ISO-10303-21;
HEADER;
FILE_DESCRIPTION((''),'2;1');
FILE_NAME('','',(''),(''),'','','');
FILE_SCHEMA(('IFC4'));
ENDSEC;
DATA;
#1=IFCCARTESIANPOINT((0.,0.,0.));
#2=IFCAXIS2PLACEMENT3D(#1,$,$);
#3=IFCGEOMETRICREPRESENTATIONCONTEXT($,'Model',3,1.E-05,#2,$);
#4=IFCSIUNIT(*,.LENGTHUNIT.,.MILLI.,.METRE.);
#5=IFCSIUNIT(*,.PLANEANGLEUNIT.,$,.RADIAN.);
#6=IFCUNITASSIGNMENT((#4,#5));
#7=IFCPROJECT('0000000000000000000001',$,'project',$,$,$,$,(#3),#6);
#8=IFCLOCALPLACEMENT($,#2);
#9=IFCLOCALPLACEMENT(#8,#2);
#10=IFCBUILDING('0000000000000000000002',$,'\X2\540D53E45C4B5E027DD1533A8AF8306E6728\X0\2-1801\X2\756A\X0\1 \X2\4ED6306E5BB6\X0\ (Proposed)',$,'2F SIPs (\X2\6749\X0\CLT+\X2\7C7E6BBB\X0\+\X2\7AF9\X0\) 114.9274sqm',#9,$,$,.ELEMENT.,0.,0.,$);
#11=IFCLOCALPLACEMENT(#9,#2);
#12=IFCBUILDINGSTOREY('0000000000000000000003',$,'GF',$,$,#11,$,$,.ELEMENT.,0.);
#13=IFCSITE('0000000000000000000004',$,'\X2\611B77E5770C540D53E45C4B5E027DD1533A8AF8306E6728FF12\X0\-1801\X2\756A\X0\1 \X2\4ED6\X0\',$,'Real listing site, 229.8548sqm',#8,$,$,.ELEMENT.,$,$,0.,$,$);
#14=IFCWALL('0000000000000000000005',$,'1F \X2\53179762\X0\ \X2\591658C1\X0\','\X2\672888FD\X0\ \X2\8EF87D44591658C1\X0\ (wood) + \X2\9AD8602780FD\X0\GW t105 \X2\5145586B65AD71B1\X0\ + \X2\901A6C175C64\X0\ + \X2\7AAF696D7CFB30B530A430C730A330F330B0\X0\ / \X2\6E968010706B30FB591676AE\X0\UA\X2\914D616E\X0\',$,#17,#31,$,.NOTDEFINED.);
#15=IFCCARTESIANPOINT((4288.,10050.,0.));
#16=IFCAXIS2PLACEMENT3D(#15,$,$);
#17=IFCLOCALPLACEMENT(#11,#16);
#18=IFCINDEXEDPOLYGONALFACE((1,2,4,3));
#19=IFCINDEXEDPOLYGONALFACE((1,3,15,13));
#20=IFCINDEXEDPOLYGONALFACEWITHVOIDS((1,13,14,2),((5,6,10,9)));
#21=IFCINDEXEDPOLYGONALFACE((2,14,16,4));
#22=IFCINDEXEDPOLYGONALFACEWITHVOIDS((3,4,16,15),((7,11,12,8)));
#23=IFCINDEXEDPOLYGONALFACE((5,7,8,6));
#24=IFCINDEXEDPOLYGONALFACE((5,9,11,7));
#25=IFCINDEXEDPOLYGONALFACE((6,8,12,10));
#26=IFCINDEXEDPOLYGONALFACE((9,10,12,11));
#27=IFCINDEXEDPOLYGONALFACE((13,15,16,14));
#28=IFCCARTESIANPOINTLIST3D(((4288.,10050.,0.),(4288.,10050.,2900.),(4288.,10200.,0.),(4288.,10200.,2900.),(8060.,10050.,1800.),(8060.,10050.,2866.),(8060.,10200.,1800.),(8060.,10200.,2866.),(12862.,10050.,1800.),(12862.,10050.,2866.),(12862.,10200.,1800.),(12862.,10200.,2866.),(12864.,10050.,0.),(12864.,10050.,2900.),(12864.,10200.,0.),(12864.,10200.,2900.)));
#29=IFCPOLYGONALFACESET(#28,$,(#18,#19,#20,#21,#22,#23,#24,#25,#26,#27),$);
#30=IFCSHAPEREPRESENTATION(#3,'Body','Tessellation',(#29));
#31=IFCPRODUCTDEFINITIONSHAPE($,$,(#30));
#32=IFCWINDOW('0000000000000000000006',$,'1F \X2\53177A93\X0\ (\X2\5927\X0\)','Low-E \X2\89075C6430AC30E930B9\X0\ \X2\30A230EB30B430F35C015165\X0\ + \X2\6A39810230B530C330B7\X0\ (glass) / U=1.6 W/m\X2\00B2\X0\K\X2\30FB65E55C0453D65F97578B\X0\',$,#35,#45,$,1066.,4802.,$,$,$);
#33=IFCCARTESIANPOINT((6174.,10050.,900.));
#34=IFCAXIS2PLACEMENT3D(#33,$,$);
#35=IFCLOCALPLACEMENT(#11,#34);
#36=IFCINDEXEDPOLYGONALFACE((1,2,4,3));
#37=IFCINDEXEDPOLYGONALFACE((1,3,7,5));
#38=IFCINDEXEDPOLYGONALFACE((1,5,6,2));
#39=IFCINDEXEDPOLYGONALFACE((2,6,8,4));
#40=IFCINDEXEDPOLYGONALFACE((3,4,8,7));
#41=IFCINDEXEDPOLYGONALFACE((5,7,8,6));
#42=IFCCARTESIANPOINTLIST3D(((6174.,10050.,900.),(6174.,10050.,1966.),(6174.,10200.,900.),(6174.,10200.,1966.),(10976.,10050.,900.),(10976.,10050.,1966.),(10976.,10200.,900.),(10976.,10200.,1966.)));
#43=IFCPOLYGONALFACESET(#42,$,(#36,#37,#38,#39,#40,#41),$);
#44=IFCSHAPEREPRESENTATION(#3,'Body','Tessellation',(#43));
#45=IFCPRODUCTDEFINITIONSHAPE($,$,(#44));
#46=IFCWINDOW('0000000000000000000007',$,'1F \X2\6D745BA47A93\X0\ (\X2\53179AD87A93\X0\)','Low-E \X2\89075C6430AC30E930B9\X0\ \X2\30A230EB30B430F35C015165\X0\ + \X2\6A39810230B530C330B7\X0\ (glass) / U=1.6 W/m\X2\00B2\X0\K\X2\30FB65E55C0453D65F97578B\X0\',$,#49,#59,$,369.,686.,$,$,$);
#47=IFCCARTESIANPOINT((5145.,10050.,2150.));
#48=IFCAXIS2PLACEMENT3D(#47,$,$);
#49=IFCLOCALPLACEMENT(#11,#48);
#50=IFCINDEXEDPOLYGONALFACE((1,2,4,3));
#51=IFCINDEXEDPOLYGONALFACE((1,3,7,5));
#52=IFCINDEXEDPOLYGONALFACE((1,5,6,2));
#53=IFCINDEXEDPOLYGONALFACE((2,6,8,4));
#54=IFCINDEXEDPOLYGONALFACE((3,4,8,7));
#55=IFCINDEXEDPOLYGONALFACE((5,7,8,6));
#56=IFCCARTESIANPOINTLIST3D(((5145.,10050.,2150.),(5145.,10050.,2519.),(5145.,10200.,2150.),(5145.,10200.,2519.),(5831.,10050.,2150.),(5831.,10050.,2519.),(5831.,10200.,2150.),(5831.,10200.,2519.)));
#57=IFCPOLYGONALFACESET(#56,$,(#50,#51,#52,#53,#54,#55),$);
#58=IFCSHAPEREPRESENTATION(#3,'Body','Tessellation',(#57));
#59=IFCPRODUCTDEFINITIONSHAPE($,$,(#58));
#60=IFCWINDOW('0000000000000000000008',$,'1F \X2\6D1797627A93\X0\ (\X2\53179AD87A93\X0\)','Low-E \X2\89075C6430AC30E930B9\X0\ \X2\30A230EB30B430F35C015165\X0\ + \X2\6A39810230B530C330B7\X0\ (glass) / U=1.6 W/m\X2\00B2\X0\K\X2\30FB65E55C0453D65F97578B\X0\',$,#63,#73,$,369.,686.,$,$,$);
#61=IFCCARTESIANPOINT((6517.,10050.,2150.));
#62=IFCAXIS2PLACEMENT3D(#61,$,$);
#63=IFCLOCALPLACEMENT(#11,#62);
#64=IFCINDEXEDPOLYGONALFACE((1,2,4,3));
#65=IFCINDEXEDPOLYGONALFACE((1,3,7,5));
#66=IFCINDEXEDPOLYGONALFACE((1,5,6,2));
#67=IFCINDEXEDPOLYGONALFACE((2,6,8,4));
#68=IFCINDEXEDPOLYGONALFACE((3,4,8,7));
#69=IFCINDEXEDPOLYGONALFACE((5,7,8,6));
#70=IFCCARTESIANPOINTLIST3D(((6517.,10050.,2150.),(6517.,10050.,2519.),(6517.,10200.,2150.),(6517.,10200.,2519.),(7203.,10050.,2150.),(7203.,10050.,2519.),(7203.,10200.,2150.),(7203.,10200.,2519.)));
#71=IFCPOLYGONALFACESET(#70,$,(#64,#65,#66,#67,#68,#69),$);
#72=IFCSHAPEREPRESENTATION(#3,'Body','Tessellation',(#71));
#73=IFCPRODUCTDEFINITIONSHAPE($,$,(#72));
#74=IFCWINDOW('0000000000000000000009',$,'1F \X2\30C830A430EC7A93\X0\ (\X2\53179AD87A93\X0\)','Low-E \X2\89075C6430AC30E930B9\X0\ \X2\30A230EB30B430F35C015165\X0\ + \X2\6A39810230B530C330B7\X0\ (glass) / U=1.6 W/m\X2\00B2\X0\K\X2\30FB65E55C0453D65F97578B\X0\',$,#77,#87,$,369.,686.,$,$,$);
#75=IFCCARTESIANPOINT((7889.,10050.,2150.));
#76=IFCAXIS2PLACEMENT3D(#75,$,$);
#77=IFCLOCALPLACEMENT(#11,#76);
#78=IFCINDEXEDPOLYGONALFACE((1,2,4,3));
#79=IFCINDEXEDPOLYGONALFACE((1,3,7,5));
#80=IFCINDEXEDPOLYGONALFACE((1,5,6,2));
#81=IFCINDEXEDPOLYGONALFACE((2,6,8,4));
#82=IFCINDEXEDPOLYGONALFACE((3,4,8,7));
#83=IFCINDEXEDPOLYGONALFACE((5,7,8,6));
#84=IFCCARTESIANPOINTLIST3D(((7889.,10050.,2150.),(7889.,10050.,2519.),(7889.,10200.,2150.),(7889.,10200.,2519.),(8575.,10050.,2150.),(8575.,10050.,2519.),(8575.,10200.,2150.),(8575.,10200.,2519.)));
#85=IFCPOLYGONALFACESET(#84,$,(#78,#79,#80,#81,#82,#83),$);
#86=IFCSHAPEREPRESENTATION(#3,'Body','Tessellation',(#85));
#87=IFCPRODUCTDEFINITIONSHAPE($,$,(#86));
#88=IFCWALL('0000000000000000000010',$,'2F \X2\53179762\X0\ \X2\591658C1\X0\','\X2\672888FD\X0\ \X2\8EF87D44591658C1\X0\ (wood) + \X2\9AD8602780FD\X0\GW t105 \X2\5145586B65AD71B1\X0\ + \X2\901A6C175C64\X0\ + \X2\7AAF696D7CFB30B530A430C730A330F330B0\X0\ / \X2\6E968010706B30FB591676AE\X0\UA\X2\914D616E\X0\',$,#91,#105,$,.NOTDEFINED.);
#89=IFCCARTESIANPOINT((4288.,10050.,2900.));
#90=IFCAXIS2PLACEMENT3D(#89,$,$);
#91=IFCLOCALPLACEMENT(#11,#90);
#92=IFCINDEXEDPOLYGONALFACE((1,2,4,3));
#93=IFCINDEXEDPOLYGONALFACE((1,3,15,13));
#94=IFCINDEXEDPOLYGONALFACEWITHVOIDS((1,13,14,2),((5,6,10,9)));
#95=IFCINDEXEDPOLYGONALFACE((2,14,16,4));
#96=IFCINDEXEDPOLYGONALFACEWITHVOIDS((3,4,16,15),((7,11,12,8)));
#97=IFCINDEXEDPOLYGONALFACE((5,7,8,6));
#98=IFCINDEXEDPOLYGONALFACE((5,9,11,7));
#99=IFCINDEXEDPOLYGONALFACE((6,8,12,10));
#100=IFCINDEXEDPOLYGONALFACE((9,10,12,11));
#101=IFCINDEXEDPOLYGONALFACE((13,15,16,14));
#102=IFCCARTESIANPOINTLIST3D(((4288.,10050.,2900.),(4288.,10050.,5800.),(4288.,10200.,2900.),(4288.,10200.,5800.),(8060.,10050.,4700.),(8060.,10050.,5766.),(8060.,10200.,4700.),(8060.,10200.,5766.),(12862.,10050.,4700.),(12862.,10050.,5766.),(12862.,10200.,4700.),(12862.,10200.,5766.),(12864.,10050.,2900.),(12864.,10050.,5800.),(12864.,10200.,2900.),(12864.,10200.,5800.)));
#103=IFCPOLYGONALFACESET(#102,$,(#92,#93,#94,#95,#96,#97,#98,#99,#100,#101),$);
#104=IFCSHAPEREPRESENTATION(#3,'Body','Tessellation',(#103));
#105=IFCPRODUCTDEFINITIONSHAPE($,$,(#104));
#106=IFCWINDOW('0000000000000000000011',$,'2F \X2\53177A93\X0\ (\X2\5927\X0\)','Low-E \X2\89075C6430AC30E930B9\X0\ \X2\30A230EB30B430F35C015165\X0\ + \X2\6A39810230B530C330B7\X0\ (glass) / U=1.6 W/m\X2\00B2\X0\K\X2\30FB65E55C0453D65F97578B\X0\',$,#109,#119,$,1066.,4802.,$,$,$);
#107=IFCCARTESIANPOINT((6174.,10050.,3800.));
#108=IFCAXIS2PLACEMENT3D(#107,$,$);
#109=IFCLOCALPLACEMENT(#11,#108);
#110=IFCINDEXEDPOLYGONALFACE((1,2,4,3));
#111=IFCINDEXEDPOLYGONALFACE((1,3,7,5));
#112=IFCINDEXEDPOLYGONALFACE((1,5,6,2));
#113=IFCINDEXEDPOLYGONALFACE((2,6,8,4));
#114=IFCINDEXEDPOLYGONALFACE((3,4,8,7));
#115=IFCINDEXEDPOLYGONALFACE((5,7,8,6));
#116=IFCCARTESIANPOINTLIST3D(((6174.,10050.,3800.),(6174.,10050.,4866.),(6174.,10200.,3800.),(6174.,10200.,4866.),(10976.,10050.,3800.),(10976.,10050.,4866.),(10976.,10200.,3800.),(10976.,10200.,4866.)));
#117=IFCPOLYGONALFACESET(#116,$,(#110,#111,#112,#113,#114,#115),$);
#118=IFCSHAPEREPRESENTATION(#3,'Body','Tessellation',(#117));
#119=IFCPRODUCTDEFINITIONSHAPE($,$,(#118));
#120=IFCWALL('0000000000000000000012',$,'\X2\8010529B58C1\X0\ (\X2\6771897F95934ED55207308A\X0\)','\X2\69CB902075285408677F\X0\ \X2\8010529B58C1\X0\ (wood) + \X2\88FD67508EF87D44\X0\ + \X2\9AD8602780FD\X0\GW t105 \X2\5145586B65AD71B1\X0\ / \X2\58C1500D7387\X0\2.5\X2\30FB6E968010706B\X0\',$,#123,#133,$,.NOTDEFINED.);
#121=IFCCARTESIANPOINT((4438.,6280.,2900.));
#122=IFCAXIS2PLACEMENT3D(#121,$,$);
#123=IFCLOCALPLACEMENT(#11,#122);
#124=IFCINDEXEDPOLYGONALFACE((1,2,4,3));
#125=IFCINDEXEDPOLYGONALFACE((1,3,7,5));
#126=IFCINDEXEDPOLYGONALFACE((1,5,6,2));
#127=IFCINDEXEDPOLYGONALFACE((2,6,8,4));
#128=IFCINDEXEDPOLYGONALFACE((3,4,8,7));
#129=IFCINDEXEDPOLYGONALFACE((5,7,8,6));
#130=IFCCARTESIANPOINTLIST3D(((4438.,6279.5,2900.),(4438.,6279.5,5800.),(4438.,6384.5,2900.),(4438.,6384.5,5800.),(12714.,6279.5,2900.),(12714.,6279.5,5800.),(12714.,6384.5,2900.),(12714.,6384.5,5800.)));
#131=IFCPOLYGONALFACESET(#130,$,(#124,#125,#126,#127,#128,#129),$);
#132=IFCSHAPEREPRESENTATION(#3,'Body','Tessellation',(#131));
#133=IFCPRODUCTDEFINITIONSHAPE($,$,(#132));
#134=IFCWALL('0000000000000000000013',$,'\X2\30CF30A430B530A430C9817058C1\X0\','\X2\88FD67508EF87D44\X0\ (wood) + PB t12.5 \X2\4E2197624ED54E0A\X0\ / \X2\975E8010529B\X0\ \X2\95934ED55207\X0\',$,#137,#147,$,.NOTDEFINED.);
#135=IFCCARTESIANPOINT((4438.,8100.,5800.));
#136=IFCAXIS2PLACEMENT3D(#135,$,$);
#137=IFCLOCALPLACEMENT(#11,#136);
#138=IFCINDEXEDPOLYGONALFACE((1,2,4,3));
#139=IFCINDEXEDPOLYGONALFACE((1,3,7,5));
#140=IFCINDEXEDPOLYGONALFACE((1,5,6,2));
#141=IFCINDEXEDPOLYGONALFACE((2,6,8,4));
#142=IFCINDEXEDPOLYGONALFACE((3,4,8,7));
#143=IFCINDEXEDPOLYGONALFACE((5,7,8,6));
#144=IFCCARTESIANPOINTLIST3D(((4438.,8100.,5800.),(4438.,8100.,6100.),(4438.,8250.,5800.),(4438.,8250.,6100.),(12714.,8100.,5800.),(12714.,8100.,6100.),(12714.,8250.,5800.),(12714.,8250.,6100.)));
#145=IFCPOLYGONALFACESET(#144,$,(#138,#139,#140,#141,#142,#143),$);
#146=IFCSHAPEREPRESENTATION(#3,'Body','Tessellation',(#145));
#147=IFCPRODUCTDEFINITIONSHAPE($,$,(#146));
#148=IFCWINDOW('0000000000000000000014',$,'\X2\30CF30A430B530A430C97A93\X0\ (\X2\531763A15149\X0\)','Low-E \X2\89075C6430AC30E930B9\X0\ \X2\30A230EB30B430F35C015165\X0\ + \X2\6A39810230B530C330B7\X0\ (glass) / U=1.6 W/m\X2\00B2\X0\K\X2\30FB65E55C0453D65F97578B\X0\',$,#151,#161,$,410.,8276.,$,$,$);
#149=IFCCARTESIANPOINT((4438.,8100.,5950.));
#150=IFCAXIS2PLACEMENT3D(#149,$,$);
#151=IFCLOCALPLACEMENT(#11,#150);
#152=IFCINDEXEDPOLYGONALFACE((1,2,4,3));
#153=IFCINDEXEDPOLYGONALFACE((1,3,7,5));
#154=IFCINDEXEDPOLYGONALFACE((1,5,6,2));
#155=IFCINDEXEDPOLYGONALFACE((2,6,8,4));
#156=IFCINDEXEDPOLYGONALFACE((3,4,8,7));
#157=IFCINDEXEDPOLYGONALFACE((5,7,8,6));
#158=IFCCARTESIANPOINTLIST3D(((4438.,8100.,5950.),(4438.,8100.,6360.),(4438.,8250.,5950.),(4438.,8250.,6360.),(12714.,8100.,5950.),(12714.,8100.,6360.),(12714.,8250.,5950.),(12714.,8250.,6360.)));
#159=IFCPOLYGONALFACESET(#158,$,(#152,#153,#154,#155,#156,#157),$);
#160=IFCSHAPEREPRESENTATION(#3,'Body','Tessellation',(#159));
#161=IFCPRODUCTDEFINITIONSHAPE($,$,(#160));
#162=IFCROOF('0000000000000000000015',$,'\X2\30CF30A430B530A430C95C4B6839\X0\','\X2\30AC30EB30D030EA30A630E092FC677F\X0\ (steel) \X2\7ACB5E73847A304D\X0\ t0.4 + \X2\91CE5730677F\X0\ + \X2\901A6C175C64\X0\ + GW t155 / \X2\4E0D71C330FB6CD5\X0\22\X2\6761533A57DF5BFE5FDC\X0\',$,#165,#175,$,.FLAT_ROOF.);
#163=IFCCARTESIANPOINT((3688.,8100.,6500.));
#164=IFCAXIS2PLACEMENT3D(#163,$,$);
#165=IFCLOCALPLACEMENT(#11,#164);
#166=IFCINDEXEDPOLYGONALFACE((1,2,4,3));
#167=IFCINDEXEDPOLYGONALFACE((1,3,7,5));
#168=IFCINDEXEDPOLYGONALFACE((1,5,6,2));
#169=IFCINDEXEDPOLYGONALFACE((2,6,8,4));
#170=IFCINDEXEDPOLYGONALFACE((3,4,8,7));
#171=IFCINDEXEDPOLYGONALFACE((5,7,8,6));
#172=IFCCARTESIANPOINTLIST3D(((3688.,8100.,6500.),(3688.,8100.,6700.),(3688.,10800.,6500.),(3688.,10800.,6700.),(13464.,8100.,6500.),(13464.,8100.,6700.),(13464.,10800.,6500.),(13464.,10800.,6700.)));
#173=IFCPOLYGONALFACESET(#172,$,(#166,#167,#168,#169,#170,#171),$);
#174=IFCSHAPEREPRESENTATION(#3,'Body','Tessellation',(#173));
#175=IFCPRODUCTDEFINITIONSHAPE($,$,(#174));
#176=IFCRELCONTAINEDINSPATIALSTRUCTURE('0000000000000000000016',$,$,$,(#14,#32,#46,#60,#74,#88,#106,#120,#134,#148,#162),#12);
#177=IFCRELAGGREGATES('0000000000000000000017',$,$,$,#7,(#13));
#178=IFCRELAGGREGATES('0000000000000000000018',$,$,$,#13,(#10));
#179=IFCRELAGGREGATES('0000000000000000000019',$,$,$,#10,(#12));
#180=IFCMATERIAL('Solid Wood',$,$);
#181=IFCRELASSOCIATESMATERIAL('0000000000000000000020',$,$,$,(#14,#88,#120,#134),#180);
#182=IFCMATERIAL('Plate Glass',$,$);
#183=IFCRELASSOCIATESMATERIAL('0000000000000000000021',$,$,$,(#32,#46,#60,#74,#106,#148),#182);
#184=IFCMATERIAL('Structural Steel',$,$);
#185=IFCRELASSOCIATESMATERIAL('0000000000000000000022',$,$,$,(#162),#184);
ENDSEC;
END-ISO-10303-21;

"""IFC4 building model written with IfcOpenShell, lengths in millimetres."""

from ifc_helpers import new_model, si_unit, frame, frame_2d, origin, place, context, project, spatial, rectangle, extrude, material, element, fill, save


model = new_model("IFC4")

# Units and contexts
model_context = context("Model", 3, precision=1e-05, world=origin())
ifc_project = project(units=[si_unit("LENGTHUNIT", "METRE", prefix="MILLI"), si_unit("PLANEANGLEUNIT", "RADIAN")], contexts=[model_context])

# Site, building, storey
site_placement = place(None, origin())
site = spatial("IfcSite", under=ifc_project, at=site_placement, Name="愛知県名古屋市緑区諸の木２-1801番1 他", ObjectType="Real listing site, 229.8548sqm", CompositionType="ELEMENT", RefElevation=0.0)
building_placement = place(site_placement, origin())
building = spatial("IfcBuilding", under=site, at=building_placement, Name="名古屋市緑区諸の木2-1801番1 他の家 (Proposed)", ObjectType="2F SIPs (杉CLT+籾殻+竹) 114.9274sqm", CompositionType="ELEMENT", ElevationOfRefHeight=0.0, ElevationOfTerrain=0.0)
storey_placement = place(building_placement, origin())
storey = spatial("IfcBuildingStorey", under=building, at=storey_placement, Name="GF", CompositionType="ELEMENT", Elevation=0.0)

# Wall, openings, windows
ifc_material_1 = material(Name="Solid Wood")
wall_1_placement = place(storey_placement, frame((4288.0, 10050.0, 0.0)))
wall_1 = element("IfcWall", 1, at=wall_1_placement, inside=storey, material=ifc_material_1, Name="1F 北面 外壁", Description="木製 軸組外壁 (wood) + 高性能GW t105 充填断熱 + 通気層 + 窯業系サイディング / 準耐火・外皮UA配慮", PredefinedType="NOTDEFINED", context=model_context, shape_type="SweptSolid", body=[
    extrude(rectangle(XDim=8576.0, YDim=150.0, at=frame_2d((4288.0, 75.0))), frame((4288.0, 10050.0, 0.0)), (0.0, 0.0, 1.0), 2900.0),
])
opening_1_placement = place(storey_placement, frame((6174.0, 10050.0, 900.0)))
opening_1 = element("IfcOpeningElement", 2, at=opening_1_placement, cuts=wall_1, PredefinedType="NOTDEFINED", context=model_context, shape_type="SweptSolid", body=[
    extrude(rectangle(XDim=4802.0, YDim=150.0, at=frame_2d((2401.0, 75.0))), frame((6174.0, 10050.0, 900.0)), (0.0, 0.0, 1.0), 1066.0),
])
opening_2_placement = place(storey_placement, frame((5145.0, 10050.0, 2150.0)))
opening_2 = element("IfcOpeningElement", 3, at=opening_2_placement, cuts=wall_1, PredefinedType="NOTDEFINED", context=model_context, shape_type="SweptSolid", body=[
    extrude(rectangle(XDim=686.0, YDim=150.0, at=frame_2d((343.0, 75.0))), frame((5145.0, 10050.0, 2150.0)), (0.0, 0.0, 1.0), 369.0),
])
opening_3_placement = place(storey_placement, frame((6517.0, 10050.0, 2150.0)))
opening_3 = element("IfcOpeningElement", 4, at=opening_3_placement, cuts=wall_1, PredefinedType="NOTDEFINED", context=model_context, shape_type="SweptSolid", body=[
    extrude(rectangle(XDim=686.0, YDim=150.0, at=frame_2d((343.0, 75.0))), frame((6517.0, 10050.0, 2150.0)), (0.0, 0.0, 1.0), 369.0),
])
opening_4_placement = place(storey_placement, frame((7889.0, 10050.0, 2150.0)))
opening_4 = element("IfcOpeningElement", 5, at=opening_4_placement, cuts=wall_1, PredefinedType="NOTDEFINED", context=model_context, shape_type="SweptSolid", body=[
    extrude(rectangle(XDim=686.0, YDim=150.0, at=frame_2d((343.0, 75.0))), frame((7889.0, 10050.0, 2150.0)), (0.0, 0.0, 1.0), 369.0),
])
ifc_material_2 = material(Name="Plate Glass")
window_1_placement = place(storey_placement, frame((6174.0, 10050.0, 900.0)))
window_1 = element("IfcWindow", 6, at=window_1_placement, inside=storey, material=ifc_material_2, Name="1F 北窓 (大)", Description="Low-E 複層ガラス アルゴン封入 + 樹脂サッシ (glass) / U=1.6 W/m²K・日射取得型", OverallHeight=1066.0, OverallWidth=4802.0, context=model_context, shape_type="SweptSolid", body=[
    extrude(rectangle(XDim=4802.0, YDim=150.0, at=frame_2d((2401.0, 75.0))), frame((6174.0, 10050.0, 900.0)), (0.0, 0.0, 1.0), 1066.0),
])
fill(opening_1, window_1)
window_2_placement = place(storey_placement, frame((5145.0, 10050.0, 2150.0)))
window_2 = element("IfcWindow", 7, at=window_2_placement, inside=storey, material=ifc_material_2, Name="1F 浴室窓 (北高窓)", Description="Low-E 複層ガラス アルゴン封入 + 樹脂サッシ (glass) / U=1.6 W/m²K・日射取得型", OverallHeight=369.0, OverallWidth=686.0, context=model_context, shape_type="SweptSolid", body=[
    extrude(rectangle(XDim=686.0, YDim=150.0, at=frame_2d((343.0, 75.0))), frame((5145.0, 10050.0, 2150.0)), (0.0, 0.0, 1.0), 369.0),
])
fill(opening_2, window_2)
window_3_placement = place(storey_placement, frame((6517.0, 10050.0, 2150.0)))
window_3 = element("IfcWindow", 8, at=window_3_placement, inside=storey, material=ifc_material_2, Name="1F 洗面窓 (北高窓)", Description="Low-E 複層ガラス アルゴン封入 + 樹脂サッシ (glass) / U=1.6 W/m²K・日射取得型", OverallHeight=369.0, OverallWidth=686.0, context=model_context, shape_type="SweptSolid", body=[
    extrude(rectangle(XDim=686.0, YDim=150.0, at=frame_2d((343.0, 75.0))), frame((6517.0, 10050.0, 2150.0)), (0.0, 0.0, 1.0), 369.0),
])
fill(opening_3, window_3)
window_4_placement = place(storey_placement, frame((7889.0, 10050.0, 2150.0)))
window_4 = element("IfcWindow", 9, at=window_4_placement, inside=storey, material=ifc_material_2, Name="1F トイレ窓 (北高窓)", Description="Low-E 複層ガラス アルゴン封入 + 樹脂サッシ (glass) / U=1.6 W/m²K・日射取得型", OverallHeight=369.0, OverallWidth=686.0, context=model_context, shape_type="SweptSolid", body=[
    extrude(rectangle(XDim=686.0, YDim=150.0, at=frame_2d((343.0, 75.0))), frame((7889.0, 10050.0, 2150.0)), (0.0, 0.0, 1.0), 369.0),
])
fill(opening_4, window_4)

# Wall, opening, window
wall_2_placement = place(storey_placement, frame((4288.0, 10050.0, 2900.0)))
wall_2 = element("IfcWall", 10, at=wall_2_placement, inside=storey, material=ifc_material_1, Name="2F 北面 外壁", Description="木製 軸組外壁 (wood) + 高性能GW t105 充填断熱 + 通気層 + 窯業系サイディング / 準耐火・外皮UA配慮", PredefinedType="NOTDEFINED", context=model_context, shape_type="SweptSolid", body=[
    extrude(rectangle(XDim=8576.0, YDim=150.0, at=frame_2d((4288.0, 75.0))), frame((4288.0, 10050.0, 2900.0)), (0.0, 0.0, 1.0), 2900.0),
])
opening_5_placement = place(storey_placement, frame((6174.0, 10050.0, 3800.0)))
opening_5 = element("IfcOpeningElement", 11, at=opening_5_placement, cuts=wall_2, PredefinedType="NOTDEFINED", context=model_context, shape_type="SweptSolid", body=[
    extrude(rectangle(XDim=4802.0, YDim=150.0, at=frame_2d((2401.0, 75.0))), frame((6174.0, 10050.0, 3800.0)), (0.0, 0.0, 1.0), 1066.0),
])
window_5_placement = place(storey_placement, frame((6174.0, 10050.0, 3800.0)))
window_5 = element("IfcWindow", 12, at=window_5_placement, inside=storey, material=ifc_material_2, Name="2F 北窓 (大)", Description="Low-E 複層ガラス アルゴン封入 + 樹脂サッシ (glass) / U=1.6 W/m²K・日射取得型", OverallHeight=1066.0, OverallWidth=4802.0, context=model_context, shape_type="SweptSolid", body=[
    extrude(rectangle(XDim=4802.0, YDim=150.0, at=frame_2d((2401.0, 75.0))), frame((6174.0, 10050.0, 3800.0)), (0.0, 0.0, 1.0), 1066.0),
])
fill(opening_5, window_5)

# Wall
wall_3_placement = place(storey_placement, frame((4438.0, 6280.0, 2900.0)))
element("IfcWall", 13, at=wall_3_placement, inside=storey, material=ifc_material_1, Name="耐力壁 (東西間仕切り)", Description="構造用合板 耐力壁 (wood) + 製材軸組 + 高性能GW t105 充填断熱 / 壁倍率2.5・準耐火", PredefinedType="NOTDEFINED", context=model_context, shape_type="SweptSolid", body=[
    extrude(rectangle(XDim=8276.0, YDim=105.0, at=frame_2d((4138.0, 52.0))), frame((4438.0, 6280.0, 2900.0)), (0.0, 0.0, 1.0), 2900.0),
])

# Wall, opening, window
wall_4_placement = place(storey_placement, frame((4438.0, 8100.0, 5800.0)))
wall_4 = element("IfcWall", 14, at=wall_4_placement, inside=storey, material=ifc_material_1, Name="ハイサイド腰壁", Description="製材軸組 (wood) + PB t12.5 両面仕上 / 非耐力 間仕切", PredefinedType="NOTDEFINED", context=model_context, shape_type="SweptSolid", body=[
    extrude(rectangle(XDim=8276.0, YDim=150.0, at=frame_2d((4138.0, 75.0))), frame((4438.0, 8100.0, 5800.0)), (0.0, 0.0, 1.0), 700.0),
])
opening_6_placement = place(storey_placement, frame((4438.0, 8100.0, 5950.0)))
opening_6 = element("IfcOpeningElement", 15, at=opening_6_placement, cuts=wall_4, PredefinedType="NOTDEFINED", context=model_context, shape_type="SweptSolid", body=[
    extrude(rectangle(XDim=8276.0, YDim=150.0, at=frame_2d((4138.0, 75.0))), frame((4438.0, 8100.0, 5950.0)), (0.0, 0.0, 1.0), 410.0),
])
window_6_placement = place(storey_placement, frame((4438.0, 8100.0, 5950.0)))
window_6 = element("IfcWindow", 16, at=window_6_placement, inside=storey, material=ifc_material_2, Name="ハイサイド窓 (北採光)", Description="Low-E 複層ガラス アルゴン封入 + 樹脂サッシ (glass) / U=1.6 W/m²K・日射取得型", OverallHeight=410.0, OverallWidth=8276.0, context=model_context, shape_type="SweptSolid", body=[
    extrude(rectangle(XDim=8276.0, YDim=150.0, at=frame_2d((4138.0, 75.0))), frame((4438.0, 8100.0, 5950.0)), (0.0, 0.0, 1.0), 410.0),
])
fill(opening_6, window_6)

# Roof
ifc_material_3 = material(Name="Structural Steel")
roof_placement = place(storey_placement, frame((3688.0, 8100.0, 6500.0)))
element("IfcRoof", 17, at=roof_placement, inside=storey, material=ifc_material_3, Name="ハイサイド屋根", Description="ガルバリウム鋼板 (steel) 立平葺き t0.4 + 野地板 + 通気層 + GW t155 / 不燃・法22条区域対応", PredefinedType="FLAT_ROOF", context=model_context, shape_type="SweptSolid", body=[
    extrude(rectangle(XDim=9776.0, YDim=2700.0, at=frame_2d((4888.0, 1350.0))), frame((3688.0, 8100.0, 6500.0)), (0.0, 0.0, 1.0), 200.0),
])

save(model, "model.ifc")
